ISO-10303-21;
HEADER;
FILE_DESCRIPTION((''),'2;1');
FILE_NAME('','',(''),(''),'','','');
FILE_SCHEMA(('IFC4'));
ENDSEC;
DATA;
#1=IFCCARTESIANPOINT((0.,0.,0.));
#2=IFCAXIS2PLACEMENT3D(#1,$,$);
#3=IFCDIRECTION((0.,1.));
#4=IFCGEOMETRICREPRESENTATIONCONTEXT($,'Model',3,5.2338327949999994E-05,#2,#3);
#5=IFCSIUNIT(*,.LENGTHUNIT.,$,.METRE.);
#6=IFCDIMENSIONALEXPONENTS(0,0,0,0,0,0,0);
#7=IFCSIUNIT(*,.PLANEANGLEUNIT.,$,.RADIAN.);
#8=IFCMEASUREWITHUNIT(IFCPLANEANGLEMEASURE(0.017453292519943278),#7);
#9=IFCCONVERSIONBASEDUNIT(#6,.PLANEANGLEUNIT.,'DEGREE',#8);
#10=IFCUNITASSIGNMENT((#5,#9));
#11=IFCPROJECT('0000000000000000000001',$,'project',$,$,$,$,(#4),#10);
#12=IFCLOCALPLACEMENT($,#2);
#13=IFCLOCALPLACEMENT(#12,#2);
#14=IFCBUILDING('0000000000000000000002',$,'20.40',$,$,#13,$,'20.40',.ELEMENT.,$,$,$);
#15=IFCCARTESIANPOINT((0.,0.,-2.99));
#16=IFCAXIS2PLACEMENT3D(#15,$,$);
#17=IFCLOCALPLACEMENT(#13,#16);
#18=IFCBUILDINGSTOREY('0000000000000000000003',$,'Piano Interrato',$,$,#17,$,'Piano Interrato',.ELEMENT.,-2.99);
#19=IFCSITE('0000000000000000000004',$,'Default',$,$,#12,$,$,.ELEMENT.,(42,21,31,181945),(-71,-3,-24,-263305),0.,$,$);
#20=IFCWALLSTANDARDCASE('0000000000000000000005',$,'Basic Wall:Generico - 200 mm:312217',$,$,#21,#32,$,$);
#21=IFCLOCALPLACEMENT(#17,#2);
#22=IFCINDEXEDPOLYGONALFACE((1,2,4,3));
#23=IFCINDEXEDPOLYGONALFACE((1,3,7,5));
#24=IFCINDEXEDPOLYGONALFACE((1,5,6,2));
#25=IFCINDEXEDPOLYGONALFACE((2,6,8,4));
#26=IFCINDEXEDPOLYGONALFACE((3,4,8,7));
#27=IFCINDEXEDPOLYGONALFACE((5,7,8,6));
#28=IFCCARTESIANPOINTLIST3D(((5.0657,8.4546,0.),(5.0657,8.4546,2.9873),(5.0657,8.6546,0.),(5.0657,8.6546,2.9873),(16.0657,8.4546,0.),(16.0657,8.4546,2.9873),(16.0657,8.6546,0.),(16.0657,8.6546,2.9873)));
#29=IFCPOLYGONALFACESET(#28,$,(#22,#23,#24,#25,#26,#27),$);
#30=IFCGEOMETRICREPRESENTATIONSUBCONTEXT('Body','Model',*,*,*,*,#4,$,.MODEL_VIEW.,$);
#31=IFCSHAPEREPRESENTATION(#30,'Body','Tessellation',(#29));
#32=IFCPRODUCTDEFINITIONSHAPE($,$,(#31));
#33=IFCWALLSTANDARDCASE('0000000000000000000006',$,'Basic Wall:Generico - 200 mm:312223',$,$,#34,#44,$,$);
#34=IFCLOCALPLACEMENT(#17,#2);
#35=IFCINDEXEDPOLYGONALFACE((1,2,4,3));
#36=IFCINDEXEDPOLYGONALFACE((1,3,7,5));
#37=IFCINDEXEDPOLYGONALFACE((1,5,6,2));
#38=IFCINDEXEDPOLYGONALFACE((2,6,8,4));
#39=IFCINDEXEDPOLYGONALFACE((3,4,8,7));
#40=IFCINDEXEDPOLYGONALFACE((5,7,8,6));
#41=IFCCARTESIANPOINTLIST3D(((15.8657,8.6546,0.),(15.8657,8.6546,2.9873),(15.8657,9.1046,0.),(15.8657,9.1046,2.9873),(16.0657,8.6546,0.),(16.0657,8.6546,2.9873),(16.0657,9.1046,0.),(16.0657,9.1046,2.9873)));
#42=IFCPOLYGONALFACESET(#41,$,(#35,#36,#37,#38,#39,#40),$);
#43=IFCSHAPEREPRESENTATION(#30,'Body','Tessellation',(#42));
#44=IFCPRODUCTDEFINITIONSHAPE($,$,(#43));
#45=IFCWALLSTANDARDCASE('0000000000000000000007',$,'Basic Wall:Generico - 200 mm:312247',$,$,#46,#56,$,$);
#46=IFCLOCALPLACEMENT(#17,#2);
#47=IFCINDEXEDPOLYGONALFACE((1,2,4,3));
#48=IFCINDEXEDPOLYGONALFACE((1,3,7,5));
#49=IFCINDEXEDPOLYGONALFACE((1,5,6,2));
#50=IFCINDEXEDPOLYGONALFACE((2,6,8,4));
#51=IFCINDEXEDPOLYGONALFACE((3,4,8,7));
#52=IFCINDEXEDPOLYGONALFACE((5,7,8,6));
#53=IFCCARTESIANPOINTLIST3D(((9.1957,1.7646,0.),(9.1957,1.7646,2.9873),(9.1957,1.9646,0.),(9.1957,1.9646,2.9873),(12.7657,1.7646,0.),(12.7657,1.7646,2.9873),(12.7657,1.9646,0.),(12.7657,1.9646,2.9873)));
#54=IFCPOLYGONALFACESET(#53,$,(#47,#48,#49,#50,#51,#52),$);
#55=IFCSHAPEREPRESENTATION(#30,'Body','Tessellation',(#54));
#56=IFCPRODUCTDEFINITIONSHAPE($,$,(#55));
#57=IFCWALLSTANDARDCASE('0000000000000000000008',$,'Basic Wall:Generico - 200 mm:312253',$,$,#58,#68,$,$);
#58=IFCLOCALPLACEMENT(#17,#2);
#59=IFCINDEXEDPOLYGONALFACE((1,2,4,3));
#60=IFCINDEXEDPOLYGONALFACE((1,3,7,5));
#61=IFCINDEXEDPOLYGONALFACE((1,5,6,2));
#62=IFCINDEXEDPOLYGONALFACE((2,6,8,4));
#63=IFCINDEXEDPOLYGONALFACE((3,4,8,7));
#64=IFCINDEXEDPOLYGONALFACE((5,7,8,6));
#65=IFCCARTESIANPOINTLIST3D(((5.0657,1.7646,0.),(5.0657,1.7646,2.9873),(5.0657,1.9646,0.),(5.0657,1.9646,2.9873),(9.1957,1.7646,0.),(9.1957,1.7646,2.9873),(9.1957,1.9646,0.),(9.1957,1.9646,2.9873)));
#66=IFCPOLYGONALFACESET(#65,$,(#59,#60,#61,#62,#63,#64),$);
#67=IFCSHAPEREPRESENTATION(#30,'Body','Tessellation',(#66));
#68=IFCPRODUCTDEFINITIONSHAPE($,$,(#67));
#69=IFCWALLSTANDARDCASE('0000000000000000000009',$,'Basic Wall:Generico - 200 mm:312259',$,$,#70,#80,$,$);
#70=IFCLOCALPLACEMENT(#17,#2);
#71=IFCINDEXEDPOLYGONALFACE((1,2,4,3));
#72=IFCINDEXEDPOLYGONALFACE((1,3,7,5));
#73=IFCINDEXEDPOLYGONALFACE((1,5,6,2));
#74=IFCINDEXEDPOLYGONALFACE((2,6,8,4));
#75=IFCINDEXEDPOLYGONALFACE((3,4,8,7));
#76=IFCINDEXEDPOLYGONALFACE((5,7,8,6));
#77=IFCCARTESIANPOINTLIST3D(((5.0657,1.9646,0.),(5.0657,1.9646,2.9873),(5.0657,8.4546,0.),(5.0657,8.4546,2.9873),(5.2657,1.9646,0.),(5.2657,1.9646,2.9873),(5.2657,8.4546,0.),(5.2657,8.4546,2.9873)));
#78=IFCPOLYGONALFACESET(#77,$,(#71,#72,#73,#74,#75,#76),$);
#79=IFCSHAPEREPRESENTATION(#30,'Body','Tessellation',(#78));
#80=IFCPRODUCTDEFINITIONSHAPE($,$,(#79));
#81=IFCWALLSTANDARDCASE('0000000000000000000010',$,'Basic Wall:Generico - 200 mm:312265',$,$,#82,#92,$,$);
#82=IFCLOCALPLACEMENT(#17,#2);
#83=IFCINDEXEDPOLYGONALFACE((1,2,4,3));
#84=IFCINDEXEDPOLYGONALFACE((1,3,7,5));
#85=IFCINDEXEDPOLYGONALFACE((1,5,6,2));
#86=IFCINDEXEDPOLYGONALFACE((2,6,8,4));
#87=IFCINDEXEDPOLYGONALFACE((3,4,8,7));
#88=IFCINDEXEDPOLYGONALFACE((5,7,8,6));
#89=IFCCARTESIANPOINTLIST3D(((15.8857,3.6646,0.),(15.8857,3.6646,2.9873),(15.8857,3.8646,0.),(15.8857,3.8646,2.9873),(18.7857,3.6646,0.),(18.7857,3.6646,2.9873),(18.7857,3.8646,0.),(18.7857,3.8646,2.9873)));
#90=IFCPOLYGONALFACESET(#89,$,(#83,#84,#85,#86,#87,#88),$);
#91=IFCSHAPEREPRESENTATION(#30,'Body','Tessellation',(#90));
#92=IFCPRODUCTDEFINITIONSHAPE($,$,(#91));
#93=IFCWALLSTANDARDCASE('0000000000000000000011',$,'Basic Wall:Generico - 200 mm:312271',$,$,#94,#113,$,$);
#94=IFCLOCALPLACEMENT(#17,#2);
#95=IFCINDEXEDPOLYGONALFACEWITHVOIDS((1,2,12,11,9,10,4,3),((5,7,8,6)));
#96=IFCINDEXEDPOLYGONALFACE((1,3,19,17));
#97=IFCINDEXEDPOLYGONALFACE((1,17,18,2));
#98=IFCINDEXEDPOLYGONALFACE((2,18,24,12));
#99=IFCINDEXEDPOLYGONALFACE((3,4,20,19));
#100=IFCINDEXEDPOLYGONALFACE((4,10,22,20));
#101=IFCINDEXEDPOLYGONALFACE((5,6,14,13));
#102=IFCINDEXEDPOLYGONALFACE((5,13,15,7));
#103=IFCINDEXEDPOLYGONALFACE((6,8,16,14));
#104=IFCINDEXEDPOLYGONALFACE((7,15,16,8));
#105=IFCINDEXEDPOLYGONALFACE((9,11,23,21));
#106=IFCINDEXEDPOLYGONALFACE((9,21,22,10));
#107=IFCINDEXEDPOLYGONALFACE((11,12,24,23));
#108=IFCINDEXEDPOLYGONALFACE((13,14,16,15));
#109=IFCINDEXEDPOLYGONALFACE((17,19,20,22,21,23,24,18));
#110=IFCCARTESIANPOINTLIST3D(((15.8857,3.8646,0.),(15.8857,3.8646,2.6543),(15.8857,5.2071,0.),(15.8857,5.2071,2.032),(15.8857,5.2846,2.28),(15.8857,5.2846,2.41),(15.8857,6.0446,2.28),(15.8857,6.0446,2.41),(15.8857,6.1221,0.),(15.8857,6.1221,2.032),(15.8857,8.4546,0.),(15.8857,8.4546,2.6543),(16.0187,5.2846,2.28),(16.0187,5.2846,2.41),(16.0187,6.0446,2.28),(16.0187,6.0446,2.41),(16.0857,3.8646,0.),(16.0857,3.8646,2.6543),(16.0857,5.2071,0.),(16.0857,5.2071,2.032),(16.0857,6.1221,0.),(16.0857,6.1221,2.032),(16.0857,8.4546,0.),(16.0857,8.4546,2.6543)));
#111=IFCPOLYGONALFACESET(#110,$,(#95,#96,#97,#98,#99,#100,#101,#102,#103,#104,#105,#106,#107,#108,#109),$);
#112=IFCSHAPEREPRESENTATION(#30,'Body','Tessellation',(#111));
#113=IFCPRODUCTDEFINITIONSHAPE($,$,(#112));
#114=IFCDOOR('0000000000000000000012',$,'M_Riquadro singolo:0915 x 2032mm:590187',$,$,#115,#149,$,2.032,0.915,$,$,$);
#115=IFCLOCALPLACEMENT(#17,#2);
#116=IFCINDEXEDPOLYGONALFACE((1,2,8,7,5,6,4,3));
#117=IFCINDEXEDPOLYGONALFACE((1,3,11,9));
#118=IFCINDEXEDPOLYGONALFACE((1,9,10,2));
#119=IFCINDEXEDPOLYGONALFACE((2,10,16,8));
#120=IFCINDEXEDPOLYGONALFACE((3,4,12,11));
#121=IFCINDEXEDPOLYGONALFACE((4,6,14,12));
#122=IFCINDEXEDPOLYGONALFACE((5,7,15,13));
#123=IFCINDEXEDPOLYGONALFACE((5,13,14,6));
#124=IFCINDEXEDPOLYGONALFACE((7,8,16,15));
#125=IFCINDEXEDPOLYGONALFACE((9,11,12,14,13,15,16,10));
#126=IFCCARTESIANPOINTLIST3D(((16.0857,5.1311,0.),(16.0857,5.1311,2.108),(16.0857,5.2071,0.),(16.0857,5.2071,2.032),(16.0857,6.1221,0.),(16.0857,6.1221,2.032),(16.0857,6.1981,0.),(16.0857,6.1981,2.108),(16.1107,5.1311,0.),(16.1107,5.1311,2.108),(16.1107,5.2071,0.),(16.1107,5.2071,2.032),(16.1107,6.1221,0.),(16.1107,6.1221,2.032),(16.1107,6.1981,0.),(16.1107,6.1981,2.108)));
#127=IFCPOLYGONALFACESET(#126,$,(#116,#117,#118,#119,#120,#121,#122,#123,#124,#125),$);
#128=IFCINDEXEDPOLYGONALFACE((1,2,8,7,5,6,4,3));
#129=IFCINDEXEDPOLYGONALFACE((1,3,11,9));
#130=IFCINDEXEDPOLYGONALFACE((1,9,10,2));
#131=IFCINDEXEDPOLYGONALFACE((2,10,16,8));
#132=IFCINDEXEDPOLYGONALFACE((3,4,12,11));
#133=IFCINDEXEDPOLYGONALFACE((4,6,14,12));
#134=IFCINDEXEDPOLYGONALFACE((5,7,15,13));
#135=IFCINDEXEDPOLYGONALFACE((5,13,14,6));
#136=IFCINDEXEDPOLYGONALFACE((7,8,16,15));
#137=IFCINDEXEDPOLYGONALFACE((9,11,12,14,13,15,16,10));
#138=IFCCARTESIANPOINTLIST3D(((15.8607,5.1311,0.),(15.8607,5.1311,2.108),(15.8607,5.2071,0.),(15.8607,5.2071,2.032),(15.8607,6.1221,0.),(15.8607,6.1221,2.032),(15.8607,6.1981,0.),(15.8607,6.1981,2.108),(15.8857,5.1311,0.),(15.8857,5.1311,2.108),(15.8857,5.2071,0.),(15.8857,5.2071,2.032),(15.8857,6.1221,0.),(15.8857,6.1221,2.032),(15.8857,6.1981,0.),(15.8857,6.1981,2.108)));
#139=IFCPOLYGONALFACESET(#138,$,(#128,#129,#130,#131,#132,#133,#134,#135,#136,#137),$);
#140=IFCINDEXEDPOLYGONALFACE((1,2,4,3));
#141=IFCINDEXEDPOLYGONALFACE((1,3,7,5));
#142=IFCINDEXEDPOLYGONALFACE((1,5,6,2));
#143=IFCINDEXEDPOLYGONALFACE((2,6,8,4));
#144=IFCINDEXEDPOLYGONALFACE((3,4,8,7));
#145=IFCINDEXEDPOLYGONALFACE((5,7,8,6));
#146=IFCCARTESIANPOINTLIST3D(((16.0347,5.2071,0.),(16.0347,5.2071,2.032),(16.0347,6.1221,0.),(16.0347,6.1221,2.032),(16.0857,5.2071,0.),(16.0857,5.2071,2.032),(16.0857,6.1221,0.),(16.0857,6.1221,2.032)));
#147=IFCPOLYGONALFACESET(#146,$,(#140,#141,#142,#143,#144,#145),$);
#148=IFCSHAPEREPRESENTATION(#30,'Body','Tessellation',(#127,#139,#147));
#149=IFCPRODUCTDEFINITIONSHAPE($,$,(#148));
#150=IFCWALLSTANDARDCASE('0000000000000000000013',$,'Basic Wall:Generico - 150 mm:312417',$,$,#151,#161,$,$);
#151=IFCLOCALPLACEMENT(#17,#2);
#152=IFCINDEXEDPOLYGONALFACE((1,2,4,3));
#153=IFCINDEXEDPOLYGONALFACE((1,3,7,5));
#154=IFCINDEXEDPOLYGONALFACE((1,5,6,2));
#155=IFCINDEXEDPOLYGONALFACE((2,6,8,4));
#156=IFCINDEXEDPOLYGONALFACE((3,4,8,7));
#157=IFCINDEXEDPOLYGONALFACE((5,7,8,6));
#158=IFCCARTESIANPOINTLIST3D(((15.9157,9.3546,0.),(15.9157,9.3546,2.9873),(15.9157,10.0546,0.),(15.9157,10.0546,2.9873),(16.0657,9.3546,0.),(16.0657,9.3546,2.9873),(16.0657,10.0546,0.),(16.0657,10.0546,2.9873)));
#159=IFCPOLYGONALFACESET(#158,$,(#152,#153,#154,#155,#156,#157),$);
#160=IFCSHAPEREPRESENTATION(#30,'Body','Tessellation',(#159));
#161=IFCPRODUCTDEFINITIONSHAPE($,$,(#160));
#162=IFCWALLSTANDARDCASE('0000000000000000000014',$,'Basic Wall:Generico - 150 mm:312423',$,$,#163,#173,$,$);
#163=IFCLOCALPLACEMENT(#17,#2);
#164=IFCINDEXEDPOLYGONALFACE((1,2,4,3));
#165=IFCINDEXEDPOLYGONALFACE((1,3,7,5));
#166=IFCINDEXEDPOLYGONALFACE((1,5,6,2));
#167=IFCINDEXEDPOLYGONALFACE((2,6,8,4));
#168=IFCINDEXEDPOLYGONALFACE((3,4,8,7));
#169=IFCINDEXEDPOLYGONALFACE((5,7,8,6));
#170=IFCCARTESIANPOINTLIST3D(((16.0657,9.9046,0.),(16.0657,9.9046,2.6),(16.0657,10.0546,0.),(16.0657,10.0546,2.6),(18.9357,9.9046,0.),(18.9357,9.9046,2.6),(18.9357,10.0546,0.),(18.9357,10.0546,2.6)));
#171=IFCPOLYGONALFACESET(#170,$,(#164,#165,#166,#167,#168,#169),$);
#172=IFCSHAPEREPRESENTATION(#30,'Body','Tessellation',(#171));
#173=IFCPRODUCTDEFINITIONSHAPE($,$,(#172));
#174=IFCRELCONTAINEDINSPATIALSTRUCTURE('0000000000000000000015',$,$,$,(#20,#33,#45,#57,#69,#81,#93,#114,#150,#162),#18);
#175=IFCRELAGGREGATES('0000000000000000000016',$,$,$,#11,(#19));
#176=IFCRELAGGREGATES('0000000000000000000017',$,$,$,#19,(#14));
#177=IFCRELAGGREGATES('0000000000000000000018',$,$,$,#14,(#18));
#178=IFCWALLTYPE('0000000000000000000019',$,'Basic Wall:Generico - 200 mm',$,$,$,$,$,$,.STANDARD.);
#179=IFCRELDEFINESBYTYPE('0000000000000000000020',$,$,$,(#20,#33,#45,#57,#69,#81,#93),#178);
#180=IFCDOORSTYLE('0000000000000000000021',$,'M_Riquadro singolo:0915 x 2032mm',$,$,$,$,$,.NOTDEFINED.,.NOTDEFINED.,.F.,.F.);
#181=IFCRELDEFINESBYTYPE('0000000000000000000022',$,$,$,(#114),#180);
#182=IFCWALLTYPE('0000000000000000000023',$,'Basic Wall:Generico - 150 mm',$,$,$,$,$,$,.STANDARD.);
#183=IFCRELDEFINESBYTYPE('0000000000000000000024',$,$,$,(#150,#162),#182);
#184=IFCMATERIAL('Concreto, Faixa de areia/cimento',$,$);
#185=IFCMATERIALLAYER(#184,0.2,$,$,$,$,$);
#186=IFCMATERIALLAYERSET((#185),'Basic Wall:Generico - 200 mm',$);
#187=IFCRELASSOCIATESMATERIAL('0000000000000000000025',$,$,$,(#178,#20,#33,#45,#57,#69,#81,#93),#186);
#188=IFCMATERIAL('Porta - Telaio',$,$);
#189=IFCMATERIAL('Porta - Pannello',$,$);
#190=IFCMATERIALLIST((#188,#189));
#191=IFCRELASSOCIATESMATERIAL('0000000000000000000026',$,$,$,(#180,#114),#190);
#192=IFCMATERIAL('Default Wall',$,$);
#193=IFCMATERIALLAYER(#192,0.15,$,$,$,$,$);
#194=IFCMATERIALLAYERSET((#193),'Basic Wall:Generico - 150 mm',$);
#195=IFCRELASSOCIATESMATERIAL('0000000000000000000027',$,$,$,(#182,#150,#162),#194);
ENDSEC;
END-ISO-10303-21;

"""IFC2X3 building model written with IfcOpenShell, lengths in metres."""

from ifc_helpers import new_model, entity, si_unit, converted_unit, direction, frame, frame_2d, origin, place, context, subcontext, project, spatial, polyline, rectangle, outline, extrude, source, transform, mapped, material, material_list, layer, layer_set, layer_usage, type_object, type_shapes, element, fill, save


model = new_model("IFC2X3")

# Units and contexts
model_context = context("Model", 3, precision=5.2338327949999994e-05, world=origin(), true_north=direction((0.0, 1.0)))
body_context = subcontext(model_context, "Body", "Model", "MODEL_VIEW")
ifc_project = project(units=[si_unit("LENGTHUNIT", "METRE"), converted_unit("PLANEANGLEUNIT", "DEGREE", entity("IfcPlaneAngleMeasure", 0.017453292519943278), si_unit("PLANEANGLEUNIT", "RADIAN"), dimensions=[0, 0, 0, 0, 0, 0, 0])], contexts=[model_context])

# Site, building, storey
site_placement = place(None, origin())
site = spatial("IfcSite", under=ifc_project, at=site_placement, Name="Default", CompositionType="ELEMENT", RefLatitude=(42, 21, 31, 181945), RefLongitude=(-71, -3, -24, -263305), RefElevation=0.0)
building_placement = place(site_placement, origin())
building = spatial("IfcBuilding", under=site, at=building_placement, Name="20.40", LongName="20.40", CompositionType="ELEMENT")
storey_placement = place(building_placement, frame((0.0, 0.0, -2.99)))
storey = spatial("IfcBuildingStorey", under=building, at=storey_placement, Name="Piano Interrato", LongName="Piano Interrato", CompositionType="ELEMENT", Elevation=-2.99)

# Walls
ifc_material_1 = material(Name="Concreto, Faixa de areia/cimento")
ifc_layer_1 = layer(ifc_material_1, 0.2)
ifc_layer_set_1 = layer_set([ifc_layer_1], Name="Basic Wall:Generico - 200 mm")
ifc_layer_usage_1 = layer_usage(ifc_layer_set_1, "AXIS2", "NEGATIVE", 0.1)
wall_type_1 = type_object("IfcWallType", Name="Basic Wall:Generico - 200 mm", PredefinedType="STANDARD", material=ifc_layer_set_1)
wall_1_placement = place(storey_placement, frame((5.0657, 8.5546, 0.0)))
element("IfcWallStandardCase", 1, at=wall_1_placement, inside=storey, type_object=wall_type_1, material=ifc_layer_usage_1, Name="Basic Wall:Generico - 200 mm:312217", context=body_context, shape_type="SweptSolid", body=[
    extrude(rectangle(XDim=11.0, YDim=0.2, at=frame_2d((5.5, 0.0), x_axis=(-1.0, 0.0))), origin(), (0.0, 0.0, 1.0), 2.9873),
])
ifc_layer_usage_2 = layer_usage(ifc_layer_set_1, "AXIS2", "NEGATIVE", 0.1)
wall_2_placement = place(storey_placement, frame((15.9657, 8.6546, 0.0), z_axis=(0.0, 0.0, 1.0), x_axis=(0.0, 1.0, 0.0)))
element("IfcWallStandardCase", 2, at=wall_2_placement, inside=storey, type_object=wall_type_1, material=ifc_layer_usage_2, Name="Basic Wall:Generico - 200 mm:312223", context=body_context, shape_type="SweptSolid", body=[
    extrude(rectangle(XDim=0.45, YDim=0.2, at=frame_2d((0.225, 0.0), x_axis=(-1.0, 0.0))), origin(), (0.0, 0.0, 1.0), 2.9873),
])

# Walls
ifc_layer_usage_3 = layer_usage(ifc_layer_set_1, "AXIS2", "NEGATIVE", 0.1)
wall_3_placement = place(storey_placement, frame((12.7657, 1.8646, 0.0), z_axis=(0.0, 0.0, 1.0), x_axis=(-1.0, 0.0, 0.0)))
element("IfcWallStandardCase", 3, at=wall_3_placement, inside=storey, type_object=wall_type_1, material=ifc_layer_usage_3, Name="Basic Wall:Generico - 200 mm:312247", context=body_context, shape_type="SweptSolid", body=[
    extrude(rectangle(XDim=3.57, YDim=0.2, at=frame_2d((1.785, 0.0), x_axis=(-1.0, 0.0))), origin(), (0.0, 0.0, 1.0), 2.9873),
])
ifc_layer_usage_4 = layer_usage(ifc_layer_set_1, "AXIS2", "NEGATIVE", 0.1)
wall_4_placement = place(storey_placement, frame((9.1957, 1.8646, 0.0), z_axis=(0.0, 0.0, 1.0), x_axis=(-1.0, 0.0, 0.0)))
element("IfcWallStandardCase", 4, at=wall_4_placement, inside=storey, type_object=wall_type_1, material=ifc_layer_usage_4, Name="Basic Wall:Generico - 200 mm:312253", context=body_context, shape_type="SweptSolid", body=[
    extrude(rectangle(XDim=4.13, YDim=0.2, at=frame_2d((2.065, 0.0), x_axis=(-1.0, 0.0))), origin(), (0.0, 0.0, 1.0), 2.9873),
])
ifc_layer_usage_5 = layer_usage(ifc_layer_set_1, "AXIS2", "NEGATIVE", 0.1)
wall_5_placement = place(storey_placement, frame((5.1657, 1.9646, 0.0), z_axis=(0.0, 0.0, 1.0), x_axis=(0.0, 1.0, 0.0)))
element("IfcWallStandardCase", 5, at=wall_5_placement, inside=storey, type_object=wall_type_1, material=ifc_layer_usage_5, Name="Basic Wall:Generico - 200 mm:312259", context=body_context, shape_type="SweptSolid", body=[
    extrude(rectangle(XDim=6.49, YDim=0.2, at=frame_2d((3.245, 0.0), x_axis=(-1.0, 0.0))), origin(), (0.0, 0.0, 1.0), 2.9873),
])
ifc_layer_usage_6 = layer_usage(ifc_layer_set_1, "AXIS2", "NEGATIVE", 0.1)
wall_6_placement = place(storey_placement, frame((15.8857, 3.7646, 0.0)))
element("IfcWallStandardCase", 6, at=wall_6_placement, inside=storey, type_object=wall_type_1, material=ifc_layer_usage_6, Name="Basic Wall:Generico - 200 mm:312265", context=body_context, shape_type="SweptSolid", body=[
    extrude(rectangle(XDim=2.9, YDim=0.2, at=frame_2d((1.45, 0.0), x_axis=(-1.0, 0.0))), origin(), (0.0, 0.0, 1.0), 2.9873),
])

# Wall, openings, door
ifc_layer_usage_7 = layer_usage(ifc_layer_set_1, "AXIS2", "NEGATIVE", 0.1)
wall_7_placement = place(storey_placement, frame((15.9857, 8.4546, 0.0), z_axis=(0.0, 0.0, 1.0), x_axis=(0.0, -1.0, 0.0)))
wall_7 = element("IfcWallStandardCase", 7, at=wall_7_placement, inside=storey, type_object=wall_type_1, material=ifc_layer_usage_7, Name="Basic Wall:Generico - 200 mm:312271", context=body_context, shape_type="SweptSolid", body=[
    extrude(rectangle(XDim=4.59, YDim=0.2, at=frame_2d((2.295, 0.0), x_axis=(1.0, 0.0))), origin(), (0.0, 0.0, 1.0), 2.6543),
])
opening_1_placement = place(wall_7_placement, origin())
element("IfcOpeningElement", 8, at=opening_1_placement, cuts=wall_7, ObjectType="Recess", context=body_context, shape_type="SweptSolid", body=[
    extrude(rectangle(XDim=0.13, YDim=0.76, at=frame_2d((0.0, 0.0), x_axis=(1.0, 0.0))), frame((2.79, -0.1, 2.345), z_axis=(0.0, 1.0, 0.0), x_axis=(0.0, 0.0, 1.0)), (0.0, 0.0, 1.0), 0.133),
])
opening_2_placement = place(wall_7_placement, frame((2.3325, -0.1, 0.0)))
opening_2 = element("IfcOpeningElement", 9, at=opening_2_placement, cuts=wall_7, ObjectType="Opening", context=body_context, shape_type="SweptSolid", body=[
    extrude(rectangle(XDim=0.915, YDim=2.032, at=frame_2d((1.016, 0.4575), x_axis=(0.0, 1.0))), frame((0.0, 0.0, 0.0), z_axis=(0.0, 1.0, 0.0), x_axis=(0.0, 0.0, 1.0)), (0.0, 0.0, 1.0), 0.2),
])
ifc_material_2 = material(Name="Porta - Telaio")
ifc_material_3 = material(Name="Porta - Pannello")
ifc_material_list_1 = material_list([ifc_material_2, ifc_material_3])
door_style = type_object("IfcDoorStyle", Name="M_Riquadro singolo:0915 x 2032mm", ConstructionType="NOTDEFINED", OperationType="NOTDEFINED", ParameterTakesPrecedence=False, Sizeable=False, material=ifc_material_list_1)
shared_shape_1 = source(origin(), body_context, "Body", "SweptSolid", [
    extrude(outline(polyline([(-0.5335, -1.073), (0.5335, -1.073), (0.5335, 1.035), (0.4575, 1.035), (0.4575, -0.997), (-0.4575, -0.997), (-0.4575, 1.035), (-0.5335, 1.035), (-0.5335, -1.073)])), frame((0.4575, 0.2, 1.035), z_axis=(0.0, 1.0, 0.0), x_axis=(1.0, 0.0, 0.0)), (0.0, 0.0, 1.0), 0.025),
    extrude(outline(polyline([(-1.073, -0.5335), (1.035, -0.5335), (1.035, -0.4575), (-0.997, -0.4575), (-0.997, 0.4575), (1.035, 0.4575), (1.035, 0.5335), (-1.073, 0.5335), (-1.073, -0.5335)])), frame((0.4575, -0.025, 1.035), z_axis=(0.0, 1.0, 0.0), x_axis=(0.0, 0.0, -1.0)), (0.0, 0.0, 1.0), 0.025),
    extrude(rectangle(XDim=0.051, YDim=0.915, at=frame_2d((0.0, 0.0), x_axis=(1.0, 0.0))), frame((0.4575, 0.1745, 0.0), z_axis=(0.0, 0.0, 1.0), x_axis=(0.0, 1.0, 0.0)), (0.0, 0.0, 1.0), 2.032),
])
type_shapes(door_style, [shared_shape_1])
door_placement = place(opening_2_placement, origin())
door = element("IfcDoor", 10, at=door_placement, inside=storey, type_object=door_style, material=ifc_material_list_1, Name="M_Riquadro singolo:0915 x 2032mm:590187", OverallHeight=2.032, OverallWidth=0.915, context=body_context, shape_type="MappedRepresentation", body=[
    mapped(shared_shape_1, transform((0.0, 0.0, 0.0), scale=1.0)),
])
fill(opening_2, door)

# Walls
ifc_material_4 = material(Name="Default Wall")
ifc_layer_2 = layer(ifc_material_4, 0.15)
ifc_layer_set_2 = layer_set([ifc_layer_2], Name="Basic Wall:Generico - 150 mm")
ifc_layer_usage_8 = layer_usage(ifc_layer_set_2, "AXIS2", "NEGATIVE", 0.075)
wall_type_2 = type_object("IfcWallType", Name="Basic Wall:Generico - 150 mm", PredefinedType="STANDARD", material=ifc_layer_set_2)
wall_8_placement = place(storey_placement, frame((15.9907, 9.3546, 0.0), z_axis=(0.0, 0.0, 1.0), x_axis=(0.0, 1.0, 0.0)))
element("IfcWallStandardCase", 11, at=wall_8_placement, inside=storey, type_object=wall_type_2, material=ifc_layer_usage_8, Name="Basic Wall:Generico - 150 mm:312417", context=body_context, shape_type="SweptSolid", body=[
    extrude(rectangle(XDim=0.7, YDim=0.15, at=frame_2d((0.35, 0.0), x_axis=(-1.0, 0.0))), origin(), (0.0, 0.0, 1.0), 2.9873),
])
ifc_layer_usage_9 = layer_usage(ifc_layer_set_2, "AXIS2", "NEGATIVE", 0.075)
wall_9_placement = place(storey_placement, frame((16.0657, 9.9796, 0.0)))
element("IfcWallStandardCase", 12, at=wall_9_placement, inside=storey, type_object=wall_type_2, material=ifc_layer_usage_9, Name="Basic Wall:Generico - 150 mm:312423", context=body_context, shape_type="SweptSolid", body=[
    extrude(rectangle(XDim=2.87, YDim=0.15, at=frame_2d((1.435, 0.0), x_axis=(-1.0, 0.0))), origin(), (0.0, 0.0, 1.0), 2.6),
])

save(model, "model.ifc")
